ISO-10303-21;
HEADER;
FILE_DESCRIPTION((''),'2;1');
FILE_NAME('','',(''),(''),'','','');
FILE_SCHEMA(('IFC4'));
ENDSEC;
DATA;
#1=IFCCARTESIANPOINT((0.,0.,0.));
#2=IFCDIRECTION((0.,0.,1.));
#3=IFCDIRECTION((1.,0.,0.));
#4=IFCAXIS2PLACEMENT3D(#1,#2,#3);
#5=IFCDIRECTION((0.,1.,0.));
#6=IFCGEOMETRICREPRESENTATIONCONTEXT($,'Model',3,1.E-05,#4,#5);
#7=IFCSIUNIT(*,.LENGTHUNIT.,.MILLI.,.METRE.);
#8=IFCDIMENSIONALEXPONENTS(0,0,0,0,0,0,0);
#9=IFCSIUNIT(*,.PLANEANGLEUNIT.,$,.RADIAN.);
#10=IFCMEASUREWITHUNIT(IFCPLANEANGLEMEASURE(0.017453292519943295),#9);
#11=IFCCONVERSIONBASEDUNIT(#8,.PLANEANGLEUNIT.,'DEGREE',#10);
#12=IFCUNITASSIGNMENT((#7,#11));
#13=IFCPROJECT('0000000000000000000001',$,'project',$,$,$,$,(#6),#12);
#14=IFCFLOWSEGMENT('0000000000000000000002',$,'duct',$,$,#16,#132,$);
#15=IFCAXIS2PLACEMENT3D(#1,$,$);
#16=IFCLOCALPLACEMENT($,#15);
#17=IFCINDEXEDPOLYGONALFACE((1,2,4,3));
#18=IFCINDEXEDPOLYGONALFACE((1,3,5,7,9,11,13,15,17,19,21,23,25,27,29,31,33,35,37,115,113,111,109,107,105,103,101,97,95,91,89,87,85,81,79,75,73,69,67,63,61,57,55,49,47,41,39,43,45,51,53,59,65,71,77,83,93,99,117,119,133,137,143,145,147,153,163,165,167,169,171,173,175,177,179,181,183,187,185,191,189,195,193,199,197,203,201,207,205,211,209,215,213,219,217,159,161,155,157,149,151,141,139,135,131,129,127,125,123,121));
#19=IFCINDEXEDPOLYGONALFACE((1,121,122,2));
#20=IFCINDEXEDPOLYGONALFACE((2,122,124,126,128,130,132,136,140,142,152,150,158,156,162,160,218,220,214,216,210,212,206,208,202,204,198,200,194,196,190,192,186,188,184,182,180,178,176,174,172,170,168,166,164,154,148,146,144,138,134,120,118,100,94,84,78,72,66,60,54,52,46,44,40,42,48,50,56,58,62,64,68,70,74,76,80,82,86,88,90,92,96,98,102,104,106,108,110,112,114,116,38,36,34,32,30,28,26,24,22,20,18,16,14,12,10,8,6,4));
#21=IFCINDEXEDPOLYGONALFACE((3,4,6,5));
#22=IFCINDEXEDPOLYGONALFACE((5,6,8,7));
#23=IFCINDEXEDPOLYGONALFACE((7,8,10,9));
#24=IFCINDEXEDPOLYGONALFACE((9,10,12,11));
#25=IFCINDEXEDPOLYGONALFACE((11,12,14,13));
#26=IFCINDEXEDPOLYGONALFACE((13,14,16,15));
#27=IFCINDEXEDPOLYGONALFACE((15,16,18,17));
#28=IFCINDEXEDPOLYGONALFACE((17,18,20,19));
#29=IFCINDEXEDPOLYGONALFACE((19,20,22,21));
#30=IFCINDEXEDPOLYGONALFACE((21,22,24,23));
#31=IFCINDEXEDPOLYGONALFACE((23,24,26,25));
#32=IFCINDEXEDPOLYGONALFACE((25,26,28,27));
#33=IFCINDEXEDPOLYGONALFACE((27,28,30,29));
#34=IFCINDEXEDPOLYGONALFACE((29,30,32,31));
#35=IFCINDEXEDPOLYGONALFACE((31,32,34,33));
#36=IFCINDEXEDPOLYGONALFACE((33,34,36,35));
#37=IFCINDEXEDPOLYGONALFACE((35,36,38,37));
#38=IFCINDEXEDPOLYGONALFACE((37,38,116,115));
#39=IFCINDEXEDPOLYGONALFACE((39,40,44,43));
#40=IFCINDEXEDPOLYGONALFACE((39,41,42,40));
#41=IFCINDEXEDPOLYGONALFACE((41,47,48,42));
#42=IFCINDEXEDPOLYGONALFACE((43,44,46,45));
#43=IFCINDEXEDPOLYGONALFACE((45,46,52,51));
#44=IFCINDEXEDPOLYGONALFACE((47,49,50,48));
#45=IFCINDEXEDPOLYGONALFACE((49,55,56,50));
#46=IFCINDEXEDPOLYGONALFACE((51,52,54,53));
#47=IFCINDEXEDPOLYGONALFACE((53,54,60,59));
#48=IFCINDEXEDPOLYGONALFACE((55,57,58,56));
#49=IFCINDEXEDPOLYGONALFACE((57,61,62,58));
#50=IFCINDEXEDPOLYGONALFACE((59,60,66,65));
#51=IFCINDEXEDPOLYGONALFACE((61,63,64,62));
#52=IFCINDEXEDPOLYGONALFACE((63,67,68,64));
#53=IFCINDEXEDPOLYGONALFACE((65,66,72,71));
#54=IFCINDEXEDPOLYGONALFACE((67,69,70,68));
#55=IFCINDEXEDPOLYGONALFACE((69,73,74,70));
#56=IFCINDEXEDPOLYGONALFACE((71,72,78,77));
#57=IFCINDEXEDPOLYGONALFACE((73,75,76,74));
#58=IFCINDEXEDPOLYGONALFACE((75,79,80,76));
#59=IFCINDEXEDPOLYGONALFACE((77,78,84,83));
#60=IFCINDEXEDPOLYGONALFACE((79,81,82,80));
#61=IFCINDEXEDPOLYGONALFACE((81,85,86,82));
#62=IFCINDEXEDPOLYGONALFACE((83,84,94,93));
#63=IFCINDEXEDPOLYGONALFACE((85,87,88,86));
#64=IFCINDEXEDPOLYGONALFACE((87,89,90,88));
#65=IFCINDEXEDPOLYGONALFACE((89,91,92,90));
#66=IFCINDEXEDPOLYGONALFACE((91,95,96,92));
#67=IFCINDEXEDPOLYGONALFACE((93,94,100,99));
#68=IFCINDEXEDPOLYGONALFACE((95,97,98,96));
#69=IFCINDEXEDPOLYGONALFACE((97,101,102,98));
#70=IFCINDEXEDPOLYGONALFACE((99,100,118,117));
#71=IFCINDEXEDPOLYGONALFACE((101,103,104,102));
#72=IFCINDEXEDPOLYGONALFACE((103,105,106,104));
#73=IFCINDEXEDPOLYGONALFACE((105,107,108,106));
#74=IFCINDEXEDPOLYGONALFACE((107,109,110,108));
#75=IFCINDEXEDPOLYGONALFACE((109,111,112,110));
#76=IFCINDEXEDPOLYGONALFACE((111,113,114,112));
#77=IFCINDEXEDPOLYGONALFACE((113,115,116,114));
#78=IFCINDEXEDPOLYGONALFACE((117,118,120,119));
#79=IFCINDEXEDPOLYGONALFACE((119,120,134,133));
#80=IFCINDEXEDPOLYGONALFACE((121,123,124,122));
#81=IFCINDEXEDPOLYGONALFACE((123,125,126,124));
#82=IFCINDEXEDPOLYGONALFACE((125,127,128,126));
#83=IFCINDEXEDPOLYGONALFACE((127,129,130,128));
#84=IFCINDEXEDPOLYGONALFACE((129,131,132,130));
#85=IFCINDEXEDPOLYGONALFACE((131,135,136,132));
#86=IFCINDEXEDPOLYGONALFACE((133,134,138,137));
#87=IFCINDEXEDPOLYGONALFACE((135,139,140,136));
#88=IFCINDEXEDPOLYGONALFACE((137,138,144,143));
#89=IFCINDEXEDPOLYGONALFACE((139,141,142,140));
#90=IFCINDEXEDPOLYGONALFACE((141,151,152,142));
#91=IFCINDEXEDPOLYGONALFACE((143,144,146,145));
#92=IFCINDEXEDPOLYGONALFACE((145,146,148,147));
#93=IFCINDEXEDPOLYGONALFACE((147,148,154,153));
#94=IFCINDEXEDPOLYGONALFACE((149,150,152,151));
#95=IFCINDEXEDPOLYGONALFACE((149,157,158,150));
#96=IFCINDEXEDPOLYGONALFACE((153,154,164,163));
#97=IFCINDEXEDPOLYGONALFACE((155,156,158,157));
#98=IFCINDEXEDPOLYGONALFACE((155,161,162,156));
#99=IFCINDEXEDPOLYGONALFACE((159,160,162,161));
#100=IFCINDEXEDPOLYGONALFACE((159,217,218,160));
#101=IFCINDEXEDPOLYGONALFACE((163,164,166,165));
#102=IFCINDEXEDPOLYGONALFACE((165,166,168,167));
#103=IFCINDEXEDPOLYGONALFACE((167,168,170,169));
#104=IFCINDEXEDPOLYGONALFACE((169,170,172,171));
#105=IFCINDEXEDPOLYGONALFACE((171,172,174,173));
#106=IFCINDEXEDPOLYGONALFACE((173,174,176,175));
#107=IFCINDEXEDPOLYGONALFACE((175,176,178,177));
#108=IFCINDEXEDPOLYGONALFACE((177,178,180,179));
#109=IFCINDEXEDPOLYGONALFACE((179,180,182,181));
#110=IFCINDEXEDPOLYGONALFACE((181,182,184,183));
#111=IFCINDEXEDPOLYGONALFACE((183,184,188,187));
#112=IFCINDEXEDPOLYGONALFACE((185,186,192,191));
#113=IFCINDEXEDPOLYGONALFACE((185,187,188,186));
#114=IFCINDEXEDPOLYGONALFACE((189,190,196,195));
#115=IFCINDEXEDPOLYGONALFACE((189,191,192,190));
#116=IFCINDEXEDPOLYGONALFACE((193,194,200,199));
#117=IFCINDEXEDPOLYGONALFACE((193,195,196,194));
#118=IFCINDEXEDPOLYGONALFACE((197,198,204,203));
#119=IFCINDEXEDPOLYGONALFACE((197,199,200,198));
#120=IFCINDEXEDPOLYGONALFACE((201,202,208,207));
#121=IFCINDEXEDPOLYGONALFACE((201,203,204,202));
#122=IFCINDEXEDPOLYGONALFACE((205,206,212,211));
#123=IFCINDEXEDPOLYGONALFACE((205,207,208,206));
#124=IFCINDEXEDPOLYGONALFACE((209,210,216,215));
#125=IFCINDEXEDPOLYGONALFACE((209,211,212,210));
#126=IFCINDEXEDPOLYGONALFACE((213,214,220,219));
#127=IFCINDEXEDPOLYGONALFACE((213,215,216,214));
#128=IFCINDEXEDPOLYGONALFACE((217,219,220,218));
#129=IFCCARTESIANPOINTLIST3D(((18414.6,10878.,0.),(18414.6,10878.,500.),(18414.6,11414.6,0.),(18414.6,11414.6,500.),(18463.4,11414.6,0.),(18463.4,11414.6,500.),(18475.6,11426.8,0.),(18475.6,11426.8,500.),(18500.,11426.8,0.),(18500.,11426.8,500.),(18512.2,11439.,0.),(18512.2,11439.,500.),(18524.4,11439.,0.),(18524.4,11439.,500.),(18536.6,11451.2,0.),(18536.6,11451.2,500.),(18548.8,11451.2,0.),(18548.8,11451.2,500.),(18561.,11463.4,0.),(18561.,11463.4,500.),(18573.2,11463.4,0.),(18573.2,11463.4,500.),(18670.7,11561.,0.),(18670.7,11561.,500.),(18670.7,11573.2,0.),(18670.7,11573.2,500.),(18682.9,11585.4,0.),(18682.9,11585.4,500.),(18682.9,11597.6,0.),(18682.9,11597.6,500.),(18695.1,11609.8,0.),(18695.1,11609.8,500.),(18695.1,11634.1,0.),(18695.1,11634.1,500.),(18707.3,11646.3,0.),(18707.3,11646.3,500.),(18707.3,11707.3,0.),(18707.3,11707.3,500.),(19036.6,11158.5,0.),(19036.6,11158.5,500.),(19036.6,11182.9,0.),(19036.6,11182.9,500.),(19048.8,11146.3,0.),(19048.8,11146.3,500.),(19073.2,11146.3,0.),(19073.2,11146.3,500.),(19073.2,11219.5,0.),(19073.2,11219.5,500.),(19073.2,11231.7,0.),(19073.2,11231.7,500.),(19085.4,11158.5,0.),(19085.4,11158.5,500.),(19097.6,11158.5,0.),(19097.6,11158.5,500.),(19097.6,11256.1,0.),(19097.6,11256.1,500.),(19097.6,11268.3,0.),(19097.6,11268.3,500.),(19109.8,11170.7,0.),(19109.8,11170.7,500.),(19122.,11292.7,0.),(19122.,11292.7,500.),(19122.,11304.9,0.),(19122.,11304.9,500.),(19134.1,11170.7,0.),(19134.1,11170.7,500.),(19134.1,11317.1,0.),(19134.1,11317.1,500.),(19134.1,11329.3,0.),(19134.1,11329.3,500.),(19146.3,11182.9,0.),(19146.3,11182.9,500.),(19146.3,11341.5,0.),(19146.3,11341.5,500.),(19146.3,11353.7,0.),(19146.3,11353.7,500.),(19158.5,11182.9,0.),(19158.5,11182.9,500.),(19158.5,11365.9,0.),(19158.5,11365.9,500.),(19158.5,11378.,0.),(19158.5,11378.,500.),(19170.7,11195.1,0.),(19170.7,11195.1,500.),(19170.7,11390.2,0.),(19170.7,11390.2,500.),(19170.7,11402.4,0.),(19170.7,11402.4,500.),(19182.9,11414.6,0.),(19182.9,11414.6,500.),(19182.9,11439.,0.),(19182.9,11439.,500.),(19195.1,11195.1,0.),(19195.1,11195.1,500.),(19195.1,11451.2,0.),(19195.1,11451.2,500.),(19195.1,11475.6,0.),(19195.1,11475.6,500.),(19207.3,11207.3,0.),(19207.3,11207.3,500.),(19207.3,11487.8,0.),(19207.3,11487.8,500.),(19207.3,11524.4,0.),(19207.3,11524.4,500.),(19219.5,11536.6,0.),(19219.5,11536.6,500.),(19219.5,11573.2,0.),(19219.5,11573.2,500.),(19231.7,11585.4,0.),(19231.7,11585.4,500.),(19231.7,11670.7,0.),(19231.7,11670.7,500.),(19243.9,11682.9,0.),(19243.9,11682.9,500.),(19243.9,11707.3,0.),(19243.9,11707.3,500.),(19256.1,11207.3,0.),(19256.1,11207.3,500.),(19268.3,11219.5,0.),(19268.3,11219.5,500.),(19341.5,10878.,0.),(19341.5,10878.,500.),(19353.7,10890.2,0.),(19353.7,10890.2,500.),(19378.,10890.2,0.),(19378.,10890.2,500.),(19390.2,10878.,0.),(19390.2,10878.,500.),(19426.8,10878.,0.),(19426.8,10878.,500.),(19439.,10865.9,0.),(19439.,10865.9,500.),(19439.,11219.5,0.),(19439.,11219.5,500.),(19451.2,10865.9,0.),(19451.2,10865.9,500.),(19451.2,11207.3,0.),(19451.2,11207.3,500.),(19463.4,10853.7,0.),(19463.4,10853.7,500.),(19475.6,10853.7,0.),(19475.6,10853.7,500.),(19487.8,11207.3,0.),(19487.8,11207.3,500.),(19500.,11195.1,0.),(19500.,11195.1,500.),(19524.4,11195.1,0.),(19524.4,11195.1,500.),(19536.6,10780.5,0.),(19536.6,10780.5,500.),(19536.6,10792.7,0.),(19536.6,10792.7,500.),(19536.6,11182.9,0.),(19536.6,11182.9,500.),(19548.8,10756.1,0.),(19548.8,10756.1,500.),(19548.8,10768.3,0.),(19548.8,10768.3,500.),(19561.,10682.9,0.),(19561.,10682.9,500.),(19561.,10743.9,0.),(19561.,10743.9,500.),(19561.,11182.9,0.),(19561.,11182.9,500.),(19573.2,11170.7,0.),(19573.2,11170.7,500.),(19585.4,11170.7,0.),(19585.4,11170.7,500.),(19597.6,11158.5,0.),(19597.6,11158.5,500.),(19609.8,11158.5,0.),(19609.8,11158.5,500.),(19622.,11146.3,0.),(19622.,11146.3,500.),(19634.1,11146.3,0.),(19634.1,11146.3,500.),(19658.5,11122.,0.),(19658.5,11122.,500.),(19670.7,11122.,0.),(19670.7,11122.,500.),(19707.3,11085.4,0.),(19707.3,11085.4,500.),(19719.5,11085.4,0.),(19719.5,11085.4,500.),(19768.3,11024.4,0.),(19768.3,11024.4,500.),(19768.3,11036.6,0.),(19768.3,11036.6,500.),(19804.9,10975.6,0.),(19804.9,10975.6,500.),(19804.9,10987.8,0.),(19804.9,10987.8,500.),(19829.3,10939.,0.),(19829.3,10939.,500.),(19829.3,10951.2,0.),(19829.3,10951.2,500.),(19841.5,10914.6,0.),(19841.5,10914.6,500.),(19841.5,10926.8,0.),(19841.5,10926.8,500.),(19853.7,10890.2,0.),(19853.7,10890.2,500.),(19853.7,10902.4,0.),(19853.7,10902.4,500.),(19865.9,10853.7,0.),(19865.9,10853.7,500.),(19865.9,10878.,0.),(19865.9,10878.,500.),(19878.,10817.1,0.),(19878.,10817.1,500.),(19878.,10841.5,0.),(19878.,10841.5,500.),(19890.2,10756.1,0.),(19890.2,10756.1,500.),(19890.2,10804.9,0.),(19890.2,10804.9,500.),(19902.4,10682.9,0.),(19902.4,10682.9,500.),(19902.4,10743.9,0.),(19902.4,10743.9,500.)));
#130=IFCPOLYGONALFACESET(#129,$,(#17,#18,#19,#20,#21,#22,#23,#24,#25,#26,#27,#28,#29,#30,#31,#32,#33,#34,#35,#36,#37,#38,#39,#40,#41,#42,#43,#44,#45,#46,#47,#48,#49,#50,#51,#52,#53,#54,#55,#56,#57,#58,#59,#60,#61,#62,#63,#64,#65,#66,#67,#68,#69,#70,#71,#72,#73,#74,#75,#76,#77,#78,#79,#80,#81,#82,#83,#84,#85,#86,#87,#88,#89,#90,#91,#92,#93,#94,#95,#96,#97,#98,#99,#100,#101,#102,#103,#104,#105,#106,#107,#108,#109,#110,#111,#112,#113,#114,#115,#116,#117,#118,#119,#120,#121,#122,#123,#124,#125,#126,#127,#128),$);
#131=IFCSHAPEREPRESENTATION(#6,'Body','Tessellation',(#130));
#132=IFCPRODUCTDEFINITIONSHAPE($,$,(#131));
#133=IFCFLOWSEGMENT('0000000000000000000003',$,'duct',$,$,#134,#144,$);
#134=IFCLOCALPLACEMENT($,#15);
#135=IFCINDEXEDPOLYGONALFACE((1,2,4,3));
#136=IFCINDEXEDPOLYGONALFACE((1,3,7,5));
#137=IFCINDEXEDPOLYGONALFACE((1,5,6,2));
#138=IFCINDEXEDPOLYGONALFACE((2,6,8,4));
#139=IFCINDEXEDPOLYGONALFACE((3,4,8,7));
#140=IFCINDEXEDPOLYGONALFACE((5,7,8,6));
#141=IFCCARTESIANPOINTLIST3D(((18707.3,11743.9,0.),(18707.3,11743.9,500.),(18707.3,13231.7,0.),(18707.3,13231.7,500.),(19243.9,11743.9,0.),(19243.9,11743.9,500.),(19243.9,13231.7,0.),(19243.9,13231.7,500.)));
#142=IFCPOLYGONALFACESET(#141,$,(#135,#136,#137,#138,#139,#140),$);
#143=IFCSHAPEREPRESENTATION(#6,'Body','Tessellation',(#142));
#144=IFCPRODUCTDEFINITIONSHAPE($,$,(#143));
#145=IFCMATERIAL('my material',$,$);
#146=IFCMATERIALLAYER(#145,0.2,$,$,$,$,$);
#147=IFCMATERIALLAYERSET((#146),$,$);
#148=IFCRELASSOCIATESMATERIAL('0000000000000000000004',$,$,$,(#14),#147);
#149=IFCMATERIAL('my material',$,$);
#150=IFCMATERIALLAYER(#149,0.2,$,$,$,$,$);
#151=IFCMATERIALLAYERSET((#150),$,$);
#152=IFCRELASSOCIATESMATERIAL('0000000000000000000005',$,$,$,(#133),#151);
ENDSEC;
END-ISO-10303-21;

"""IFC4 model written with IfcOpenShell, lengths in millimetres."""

from ifc_helpers import new_model, entity, si_unit, converted_unit, direction, origin_with_axes, place, context, project, polyline, outline, extrude, material, layer, layer_set, layer_usage, element, save


model = new_model("IFC4")

# Units and contexts
model_context = context("Model", 3, precision=1e-05, world=origin_with_axes(), true_north=direction((0.0, 1.0, 0.0)))
ifc_project = project(units=[si_unit("LENGTHUNIT", "METRE", prefix="MILLI"), converted_unit("PLANEANGLEUNIT", "DEGREE", entity("IfcPlaneAngleMeasure", 0.017453292519943295), si_unit("PLANEANGLEUNIT", "RADIAN"), dimensions=[0, 0, 0, 0, 0, 0, 0])], contexts=[model_context])

# Flow segments
ifc_material_1 = material(Name="my material")
ifc_layer_1 = layer(ifc_material_1, 0.2)
ifc_layer_set_1 = layer_set([ifc_layer_1])
ifc_layer_usage_1 = layer_usage(ifc_layer_set_1, "AXIS2", "POSITIVE", -0.1)
flow_segment_1_placement = place(None, origin_with_axes())
element("IfcFlowSegment", 1, at=flow_segment_1_placement, material=ifc_layer_usage_1, Name="duct", context=model_context, shape_type="SweptSolid", body=[
    extrude(outline(polyline([(18414.6, 10878.0), (19341.5, 10878.0), (19353.7, 10890.2), (19378.0, 10890.2), (19390.2, 10878.0), (19426.8, 10878.0), (19439.0, 10865.9), (19451.2, 10865.9), (19463.4, 10853.7), (19475.6, 10853.7), (19536.6, 10792.7), (19536.6, 10780.5), (19548.8, 10768.3), (19548.8, 10756.1), (19561.0, 10743.9), (19561.0, 10682.9), (19902.4, 10682.9), (19902.4, 10743.9), (19890.2, 10756.1), (19890.2, 10804.9), (19878.0, 10817.1), (19878.0, 10841.5), (19865.9, 10853.7), (19865.9, 10878.0), (19853.7, 10890.2), (19853.7, 10902.4), (19841.5, 10914.6), (19841.5, 10926.8), (19829.3, 10939.0), (19829.3, 10951.2), (19804.9, 10975.6), (19804.9, 10987.8), (19768.3, 11024.4), (19768.3, 11036.6), (19719.5, 11085.4), (19707.3, 11085.4), (19670.7, 11122.0), (19658.5, 11122.0), (19634.1, 11146.3), (19622.0, 11146.3), (19609.8, 11158.5), (19597.6, 11158.5), (19585.4, 11170.7), (19573.2, 11170.7), (19561.0, 11182.9), (19536.6, 11182.9), (19524.4, 11195.1), (19500.0, 11195.1), (19487.8, 11207.3), (19451.2, 11207.3), (19439.0, 11219.5), (19268.3, 11219.5), (19256.1, 11207.3), (19207.3, 11207.3), (19195.1, 11195.1), (19170.7, 11195.1), (19158.5, 11182.9), (19146.3, 11182.9), (19134.1, 11170.7), (19109.8, 11170.7), (19097.6, 11158.5), (19085.4, 11158.5), (19073.2, 11146.3), (19048.8, 11146.3), (19036.6, 11158.5), (19036.6, 11182.9), (19073.2, 11219.5), (19073.2, 11231.7), (19097.6, 11256.1), (19097.6, 11268.3), (19122.0, 11292.7), (19122.0, 11304.9), (19134.1, 11317.1), (19134.1, 11329.3), (19146.3, 11341.5), (19146.3, 11353.7), (19158.5, 11365.9), (19158.5, 11378.0), (19170.7, 11390.2), (19170.7, 11402.4), (19182.9, 11414.6), (19182.9, 11439.0), (19195.1, 11451.2), (19195.1, 11475.6), (19207.3, 11487.8), (19207.3, 11524.4), (19219.5, 11536.6), (19219.5, 11573.2), (19231.7, 11585.4), (19231.7, 11670.7), (19243.9, 11682.9), (19243.9, 11707.3), (18707.3, 11707.3), (18707.3, 11646.3), (18695.1, 11634.1), (18695.1, 11609.8), (18682.9, 11597.6), (18682.9, 11585.4), (18670.7, 11573.2), (18670.7, 11561.0), (18573.2, 11463.4), (18561.0, 11463.4), (18548.8, 11451.2), (18536.6, 11451.2), (18524.4, 11439.0), (18512.2, 11439.0), (18500.0, 11426.8), (18475.6, 11426.8), (18463.4, 11414.6), (18414.6, 11414.6), (18414.6, 10878.0)])), origin_with_axes(), (0.0, 0.0, 1.0), 500.0),
])
ifc_material_2 = material(Name="my material")
ifc_layer_2 = layer(ifc_material_2, 0.2)
ifc_layer_set_2 = layer_set([ifc_layer_2])
ifc_layer_usage_2 = layer_usage(ifc_layer_set_2, "AXIS2", "POSITIVE", -0.1)
flow_segment_2_placement = place(None, origin_with_axes())
element("IfcFlowSegment", 2, at=flow_segment_2_placement, material=ifc_layer_usage_2, Name="duct", context=model_context, shape_type="SweptSolid", body=[
    extrude(outline(polyline([(18707.3, 11743.9), (19243.9, 11743.9), (19243.9, 13231.7), (18707.3, 13231.7), (18707.3, 11743.9)])), origin_with_axes(), (0.0, 0.0, 1.0), 500.0),
])

save(model, "model.ifc")
